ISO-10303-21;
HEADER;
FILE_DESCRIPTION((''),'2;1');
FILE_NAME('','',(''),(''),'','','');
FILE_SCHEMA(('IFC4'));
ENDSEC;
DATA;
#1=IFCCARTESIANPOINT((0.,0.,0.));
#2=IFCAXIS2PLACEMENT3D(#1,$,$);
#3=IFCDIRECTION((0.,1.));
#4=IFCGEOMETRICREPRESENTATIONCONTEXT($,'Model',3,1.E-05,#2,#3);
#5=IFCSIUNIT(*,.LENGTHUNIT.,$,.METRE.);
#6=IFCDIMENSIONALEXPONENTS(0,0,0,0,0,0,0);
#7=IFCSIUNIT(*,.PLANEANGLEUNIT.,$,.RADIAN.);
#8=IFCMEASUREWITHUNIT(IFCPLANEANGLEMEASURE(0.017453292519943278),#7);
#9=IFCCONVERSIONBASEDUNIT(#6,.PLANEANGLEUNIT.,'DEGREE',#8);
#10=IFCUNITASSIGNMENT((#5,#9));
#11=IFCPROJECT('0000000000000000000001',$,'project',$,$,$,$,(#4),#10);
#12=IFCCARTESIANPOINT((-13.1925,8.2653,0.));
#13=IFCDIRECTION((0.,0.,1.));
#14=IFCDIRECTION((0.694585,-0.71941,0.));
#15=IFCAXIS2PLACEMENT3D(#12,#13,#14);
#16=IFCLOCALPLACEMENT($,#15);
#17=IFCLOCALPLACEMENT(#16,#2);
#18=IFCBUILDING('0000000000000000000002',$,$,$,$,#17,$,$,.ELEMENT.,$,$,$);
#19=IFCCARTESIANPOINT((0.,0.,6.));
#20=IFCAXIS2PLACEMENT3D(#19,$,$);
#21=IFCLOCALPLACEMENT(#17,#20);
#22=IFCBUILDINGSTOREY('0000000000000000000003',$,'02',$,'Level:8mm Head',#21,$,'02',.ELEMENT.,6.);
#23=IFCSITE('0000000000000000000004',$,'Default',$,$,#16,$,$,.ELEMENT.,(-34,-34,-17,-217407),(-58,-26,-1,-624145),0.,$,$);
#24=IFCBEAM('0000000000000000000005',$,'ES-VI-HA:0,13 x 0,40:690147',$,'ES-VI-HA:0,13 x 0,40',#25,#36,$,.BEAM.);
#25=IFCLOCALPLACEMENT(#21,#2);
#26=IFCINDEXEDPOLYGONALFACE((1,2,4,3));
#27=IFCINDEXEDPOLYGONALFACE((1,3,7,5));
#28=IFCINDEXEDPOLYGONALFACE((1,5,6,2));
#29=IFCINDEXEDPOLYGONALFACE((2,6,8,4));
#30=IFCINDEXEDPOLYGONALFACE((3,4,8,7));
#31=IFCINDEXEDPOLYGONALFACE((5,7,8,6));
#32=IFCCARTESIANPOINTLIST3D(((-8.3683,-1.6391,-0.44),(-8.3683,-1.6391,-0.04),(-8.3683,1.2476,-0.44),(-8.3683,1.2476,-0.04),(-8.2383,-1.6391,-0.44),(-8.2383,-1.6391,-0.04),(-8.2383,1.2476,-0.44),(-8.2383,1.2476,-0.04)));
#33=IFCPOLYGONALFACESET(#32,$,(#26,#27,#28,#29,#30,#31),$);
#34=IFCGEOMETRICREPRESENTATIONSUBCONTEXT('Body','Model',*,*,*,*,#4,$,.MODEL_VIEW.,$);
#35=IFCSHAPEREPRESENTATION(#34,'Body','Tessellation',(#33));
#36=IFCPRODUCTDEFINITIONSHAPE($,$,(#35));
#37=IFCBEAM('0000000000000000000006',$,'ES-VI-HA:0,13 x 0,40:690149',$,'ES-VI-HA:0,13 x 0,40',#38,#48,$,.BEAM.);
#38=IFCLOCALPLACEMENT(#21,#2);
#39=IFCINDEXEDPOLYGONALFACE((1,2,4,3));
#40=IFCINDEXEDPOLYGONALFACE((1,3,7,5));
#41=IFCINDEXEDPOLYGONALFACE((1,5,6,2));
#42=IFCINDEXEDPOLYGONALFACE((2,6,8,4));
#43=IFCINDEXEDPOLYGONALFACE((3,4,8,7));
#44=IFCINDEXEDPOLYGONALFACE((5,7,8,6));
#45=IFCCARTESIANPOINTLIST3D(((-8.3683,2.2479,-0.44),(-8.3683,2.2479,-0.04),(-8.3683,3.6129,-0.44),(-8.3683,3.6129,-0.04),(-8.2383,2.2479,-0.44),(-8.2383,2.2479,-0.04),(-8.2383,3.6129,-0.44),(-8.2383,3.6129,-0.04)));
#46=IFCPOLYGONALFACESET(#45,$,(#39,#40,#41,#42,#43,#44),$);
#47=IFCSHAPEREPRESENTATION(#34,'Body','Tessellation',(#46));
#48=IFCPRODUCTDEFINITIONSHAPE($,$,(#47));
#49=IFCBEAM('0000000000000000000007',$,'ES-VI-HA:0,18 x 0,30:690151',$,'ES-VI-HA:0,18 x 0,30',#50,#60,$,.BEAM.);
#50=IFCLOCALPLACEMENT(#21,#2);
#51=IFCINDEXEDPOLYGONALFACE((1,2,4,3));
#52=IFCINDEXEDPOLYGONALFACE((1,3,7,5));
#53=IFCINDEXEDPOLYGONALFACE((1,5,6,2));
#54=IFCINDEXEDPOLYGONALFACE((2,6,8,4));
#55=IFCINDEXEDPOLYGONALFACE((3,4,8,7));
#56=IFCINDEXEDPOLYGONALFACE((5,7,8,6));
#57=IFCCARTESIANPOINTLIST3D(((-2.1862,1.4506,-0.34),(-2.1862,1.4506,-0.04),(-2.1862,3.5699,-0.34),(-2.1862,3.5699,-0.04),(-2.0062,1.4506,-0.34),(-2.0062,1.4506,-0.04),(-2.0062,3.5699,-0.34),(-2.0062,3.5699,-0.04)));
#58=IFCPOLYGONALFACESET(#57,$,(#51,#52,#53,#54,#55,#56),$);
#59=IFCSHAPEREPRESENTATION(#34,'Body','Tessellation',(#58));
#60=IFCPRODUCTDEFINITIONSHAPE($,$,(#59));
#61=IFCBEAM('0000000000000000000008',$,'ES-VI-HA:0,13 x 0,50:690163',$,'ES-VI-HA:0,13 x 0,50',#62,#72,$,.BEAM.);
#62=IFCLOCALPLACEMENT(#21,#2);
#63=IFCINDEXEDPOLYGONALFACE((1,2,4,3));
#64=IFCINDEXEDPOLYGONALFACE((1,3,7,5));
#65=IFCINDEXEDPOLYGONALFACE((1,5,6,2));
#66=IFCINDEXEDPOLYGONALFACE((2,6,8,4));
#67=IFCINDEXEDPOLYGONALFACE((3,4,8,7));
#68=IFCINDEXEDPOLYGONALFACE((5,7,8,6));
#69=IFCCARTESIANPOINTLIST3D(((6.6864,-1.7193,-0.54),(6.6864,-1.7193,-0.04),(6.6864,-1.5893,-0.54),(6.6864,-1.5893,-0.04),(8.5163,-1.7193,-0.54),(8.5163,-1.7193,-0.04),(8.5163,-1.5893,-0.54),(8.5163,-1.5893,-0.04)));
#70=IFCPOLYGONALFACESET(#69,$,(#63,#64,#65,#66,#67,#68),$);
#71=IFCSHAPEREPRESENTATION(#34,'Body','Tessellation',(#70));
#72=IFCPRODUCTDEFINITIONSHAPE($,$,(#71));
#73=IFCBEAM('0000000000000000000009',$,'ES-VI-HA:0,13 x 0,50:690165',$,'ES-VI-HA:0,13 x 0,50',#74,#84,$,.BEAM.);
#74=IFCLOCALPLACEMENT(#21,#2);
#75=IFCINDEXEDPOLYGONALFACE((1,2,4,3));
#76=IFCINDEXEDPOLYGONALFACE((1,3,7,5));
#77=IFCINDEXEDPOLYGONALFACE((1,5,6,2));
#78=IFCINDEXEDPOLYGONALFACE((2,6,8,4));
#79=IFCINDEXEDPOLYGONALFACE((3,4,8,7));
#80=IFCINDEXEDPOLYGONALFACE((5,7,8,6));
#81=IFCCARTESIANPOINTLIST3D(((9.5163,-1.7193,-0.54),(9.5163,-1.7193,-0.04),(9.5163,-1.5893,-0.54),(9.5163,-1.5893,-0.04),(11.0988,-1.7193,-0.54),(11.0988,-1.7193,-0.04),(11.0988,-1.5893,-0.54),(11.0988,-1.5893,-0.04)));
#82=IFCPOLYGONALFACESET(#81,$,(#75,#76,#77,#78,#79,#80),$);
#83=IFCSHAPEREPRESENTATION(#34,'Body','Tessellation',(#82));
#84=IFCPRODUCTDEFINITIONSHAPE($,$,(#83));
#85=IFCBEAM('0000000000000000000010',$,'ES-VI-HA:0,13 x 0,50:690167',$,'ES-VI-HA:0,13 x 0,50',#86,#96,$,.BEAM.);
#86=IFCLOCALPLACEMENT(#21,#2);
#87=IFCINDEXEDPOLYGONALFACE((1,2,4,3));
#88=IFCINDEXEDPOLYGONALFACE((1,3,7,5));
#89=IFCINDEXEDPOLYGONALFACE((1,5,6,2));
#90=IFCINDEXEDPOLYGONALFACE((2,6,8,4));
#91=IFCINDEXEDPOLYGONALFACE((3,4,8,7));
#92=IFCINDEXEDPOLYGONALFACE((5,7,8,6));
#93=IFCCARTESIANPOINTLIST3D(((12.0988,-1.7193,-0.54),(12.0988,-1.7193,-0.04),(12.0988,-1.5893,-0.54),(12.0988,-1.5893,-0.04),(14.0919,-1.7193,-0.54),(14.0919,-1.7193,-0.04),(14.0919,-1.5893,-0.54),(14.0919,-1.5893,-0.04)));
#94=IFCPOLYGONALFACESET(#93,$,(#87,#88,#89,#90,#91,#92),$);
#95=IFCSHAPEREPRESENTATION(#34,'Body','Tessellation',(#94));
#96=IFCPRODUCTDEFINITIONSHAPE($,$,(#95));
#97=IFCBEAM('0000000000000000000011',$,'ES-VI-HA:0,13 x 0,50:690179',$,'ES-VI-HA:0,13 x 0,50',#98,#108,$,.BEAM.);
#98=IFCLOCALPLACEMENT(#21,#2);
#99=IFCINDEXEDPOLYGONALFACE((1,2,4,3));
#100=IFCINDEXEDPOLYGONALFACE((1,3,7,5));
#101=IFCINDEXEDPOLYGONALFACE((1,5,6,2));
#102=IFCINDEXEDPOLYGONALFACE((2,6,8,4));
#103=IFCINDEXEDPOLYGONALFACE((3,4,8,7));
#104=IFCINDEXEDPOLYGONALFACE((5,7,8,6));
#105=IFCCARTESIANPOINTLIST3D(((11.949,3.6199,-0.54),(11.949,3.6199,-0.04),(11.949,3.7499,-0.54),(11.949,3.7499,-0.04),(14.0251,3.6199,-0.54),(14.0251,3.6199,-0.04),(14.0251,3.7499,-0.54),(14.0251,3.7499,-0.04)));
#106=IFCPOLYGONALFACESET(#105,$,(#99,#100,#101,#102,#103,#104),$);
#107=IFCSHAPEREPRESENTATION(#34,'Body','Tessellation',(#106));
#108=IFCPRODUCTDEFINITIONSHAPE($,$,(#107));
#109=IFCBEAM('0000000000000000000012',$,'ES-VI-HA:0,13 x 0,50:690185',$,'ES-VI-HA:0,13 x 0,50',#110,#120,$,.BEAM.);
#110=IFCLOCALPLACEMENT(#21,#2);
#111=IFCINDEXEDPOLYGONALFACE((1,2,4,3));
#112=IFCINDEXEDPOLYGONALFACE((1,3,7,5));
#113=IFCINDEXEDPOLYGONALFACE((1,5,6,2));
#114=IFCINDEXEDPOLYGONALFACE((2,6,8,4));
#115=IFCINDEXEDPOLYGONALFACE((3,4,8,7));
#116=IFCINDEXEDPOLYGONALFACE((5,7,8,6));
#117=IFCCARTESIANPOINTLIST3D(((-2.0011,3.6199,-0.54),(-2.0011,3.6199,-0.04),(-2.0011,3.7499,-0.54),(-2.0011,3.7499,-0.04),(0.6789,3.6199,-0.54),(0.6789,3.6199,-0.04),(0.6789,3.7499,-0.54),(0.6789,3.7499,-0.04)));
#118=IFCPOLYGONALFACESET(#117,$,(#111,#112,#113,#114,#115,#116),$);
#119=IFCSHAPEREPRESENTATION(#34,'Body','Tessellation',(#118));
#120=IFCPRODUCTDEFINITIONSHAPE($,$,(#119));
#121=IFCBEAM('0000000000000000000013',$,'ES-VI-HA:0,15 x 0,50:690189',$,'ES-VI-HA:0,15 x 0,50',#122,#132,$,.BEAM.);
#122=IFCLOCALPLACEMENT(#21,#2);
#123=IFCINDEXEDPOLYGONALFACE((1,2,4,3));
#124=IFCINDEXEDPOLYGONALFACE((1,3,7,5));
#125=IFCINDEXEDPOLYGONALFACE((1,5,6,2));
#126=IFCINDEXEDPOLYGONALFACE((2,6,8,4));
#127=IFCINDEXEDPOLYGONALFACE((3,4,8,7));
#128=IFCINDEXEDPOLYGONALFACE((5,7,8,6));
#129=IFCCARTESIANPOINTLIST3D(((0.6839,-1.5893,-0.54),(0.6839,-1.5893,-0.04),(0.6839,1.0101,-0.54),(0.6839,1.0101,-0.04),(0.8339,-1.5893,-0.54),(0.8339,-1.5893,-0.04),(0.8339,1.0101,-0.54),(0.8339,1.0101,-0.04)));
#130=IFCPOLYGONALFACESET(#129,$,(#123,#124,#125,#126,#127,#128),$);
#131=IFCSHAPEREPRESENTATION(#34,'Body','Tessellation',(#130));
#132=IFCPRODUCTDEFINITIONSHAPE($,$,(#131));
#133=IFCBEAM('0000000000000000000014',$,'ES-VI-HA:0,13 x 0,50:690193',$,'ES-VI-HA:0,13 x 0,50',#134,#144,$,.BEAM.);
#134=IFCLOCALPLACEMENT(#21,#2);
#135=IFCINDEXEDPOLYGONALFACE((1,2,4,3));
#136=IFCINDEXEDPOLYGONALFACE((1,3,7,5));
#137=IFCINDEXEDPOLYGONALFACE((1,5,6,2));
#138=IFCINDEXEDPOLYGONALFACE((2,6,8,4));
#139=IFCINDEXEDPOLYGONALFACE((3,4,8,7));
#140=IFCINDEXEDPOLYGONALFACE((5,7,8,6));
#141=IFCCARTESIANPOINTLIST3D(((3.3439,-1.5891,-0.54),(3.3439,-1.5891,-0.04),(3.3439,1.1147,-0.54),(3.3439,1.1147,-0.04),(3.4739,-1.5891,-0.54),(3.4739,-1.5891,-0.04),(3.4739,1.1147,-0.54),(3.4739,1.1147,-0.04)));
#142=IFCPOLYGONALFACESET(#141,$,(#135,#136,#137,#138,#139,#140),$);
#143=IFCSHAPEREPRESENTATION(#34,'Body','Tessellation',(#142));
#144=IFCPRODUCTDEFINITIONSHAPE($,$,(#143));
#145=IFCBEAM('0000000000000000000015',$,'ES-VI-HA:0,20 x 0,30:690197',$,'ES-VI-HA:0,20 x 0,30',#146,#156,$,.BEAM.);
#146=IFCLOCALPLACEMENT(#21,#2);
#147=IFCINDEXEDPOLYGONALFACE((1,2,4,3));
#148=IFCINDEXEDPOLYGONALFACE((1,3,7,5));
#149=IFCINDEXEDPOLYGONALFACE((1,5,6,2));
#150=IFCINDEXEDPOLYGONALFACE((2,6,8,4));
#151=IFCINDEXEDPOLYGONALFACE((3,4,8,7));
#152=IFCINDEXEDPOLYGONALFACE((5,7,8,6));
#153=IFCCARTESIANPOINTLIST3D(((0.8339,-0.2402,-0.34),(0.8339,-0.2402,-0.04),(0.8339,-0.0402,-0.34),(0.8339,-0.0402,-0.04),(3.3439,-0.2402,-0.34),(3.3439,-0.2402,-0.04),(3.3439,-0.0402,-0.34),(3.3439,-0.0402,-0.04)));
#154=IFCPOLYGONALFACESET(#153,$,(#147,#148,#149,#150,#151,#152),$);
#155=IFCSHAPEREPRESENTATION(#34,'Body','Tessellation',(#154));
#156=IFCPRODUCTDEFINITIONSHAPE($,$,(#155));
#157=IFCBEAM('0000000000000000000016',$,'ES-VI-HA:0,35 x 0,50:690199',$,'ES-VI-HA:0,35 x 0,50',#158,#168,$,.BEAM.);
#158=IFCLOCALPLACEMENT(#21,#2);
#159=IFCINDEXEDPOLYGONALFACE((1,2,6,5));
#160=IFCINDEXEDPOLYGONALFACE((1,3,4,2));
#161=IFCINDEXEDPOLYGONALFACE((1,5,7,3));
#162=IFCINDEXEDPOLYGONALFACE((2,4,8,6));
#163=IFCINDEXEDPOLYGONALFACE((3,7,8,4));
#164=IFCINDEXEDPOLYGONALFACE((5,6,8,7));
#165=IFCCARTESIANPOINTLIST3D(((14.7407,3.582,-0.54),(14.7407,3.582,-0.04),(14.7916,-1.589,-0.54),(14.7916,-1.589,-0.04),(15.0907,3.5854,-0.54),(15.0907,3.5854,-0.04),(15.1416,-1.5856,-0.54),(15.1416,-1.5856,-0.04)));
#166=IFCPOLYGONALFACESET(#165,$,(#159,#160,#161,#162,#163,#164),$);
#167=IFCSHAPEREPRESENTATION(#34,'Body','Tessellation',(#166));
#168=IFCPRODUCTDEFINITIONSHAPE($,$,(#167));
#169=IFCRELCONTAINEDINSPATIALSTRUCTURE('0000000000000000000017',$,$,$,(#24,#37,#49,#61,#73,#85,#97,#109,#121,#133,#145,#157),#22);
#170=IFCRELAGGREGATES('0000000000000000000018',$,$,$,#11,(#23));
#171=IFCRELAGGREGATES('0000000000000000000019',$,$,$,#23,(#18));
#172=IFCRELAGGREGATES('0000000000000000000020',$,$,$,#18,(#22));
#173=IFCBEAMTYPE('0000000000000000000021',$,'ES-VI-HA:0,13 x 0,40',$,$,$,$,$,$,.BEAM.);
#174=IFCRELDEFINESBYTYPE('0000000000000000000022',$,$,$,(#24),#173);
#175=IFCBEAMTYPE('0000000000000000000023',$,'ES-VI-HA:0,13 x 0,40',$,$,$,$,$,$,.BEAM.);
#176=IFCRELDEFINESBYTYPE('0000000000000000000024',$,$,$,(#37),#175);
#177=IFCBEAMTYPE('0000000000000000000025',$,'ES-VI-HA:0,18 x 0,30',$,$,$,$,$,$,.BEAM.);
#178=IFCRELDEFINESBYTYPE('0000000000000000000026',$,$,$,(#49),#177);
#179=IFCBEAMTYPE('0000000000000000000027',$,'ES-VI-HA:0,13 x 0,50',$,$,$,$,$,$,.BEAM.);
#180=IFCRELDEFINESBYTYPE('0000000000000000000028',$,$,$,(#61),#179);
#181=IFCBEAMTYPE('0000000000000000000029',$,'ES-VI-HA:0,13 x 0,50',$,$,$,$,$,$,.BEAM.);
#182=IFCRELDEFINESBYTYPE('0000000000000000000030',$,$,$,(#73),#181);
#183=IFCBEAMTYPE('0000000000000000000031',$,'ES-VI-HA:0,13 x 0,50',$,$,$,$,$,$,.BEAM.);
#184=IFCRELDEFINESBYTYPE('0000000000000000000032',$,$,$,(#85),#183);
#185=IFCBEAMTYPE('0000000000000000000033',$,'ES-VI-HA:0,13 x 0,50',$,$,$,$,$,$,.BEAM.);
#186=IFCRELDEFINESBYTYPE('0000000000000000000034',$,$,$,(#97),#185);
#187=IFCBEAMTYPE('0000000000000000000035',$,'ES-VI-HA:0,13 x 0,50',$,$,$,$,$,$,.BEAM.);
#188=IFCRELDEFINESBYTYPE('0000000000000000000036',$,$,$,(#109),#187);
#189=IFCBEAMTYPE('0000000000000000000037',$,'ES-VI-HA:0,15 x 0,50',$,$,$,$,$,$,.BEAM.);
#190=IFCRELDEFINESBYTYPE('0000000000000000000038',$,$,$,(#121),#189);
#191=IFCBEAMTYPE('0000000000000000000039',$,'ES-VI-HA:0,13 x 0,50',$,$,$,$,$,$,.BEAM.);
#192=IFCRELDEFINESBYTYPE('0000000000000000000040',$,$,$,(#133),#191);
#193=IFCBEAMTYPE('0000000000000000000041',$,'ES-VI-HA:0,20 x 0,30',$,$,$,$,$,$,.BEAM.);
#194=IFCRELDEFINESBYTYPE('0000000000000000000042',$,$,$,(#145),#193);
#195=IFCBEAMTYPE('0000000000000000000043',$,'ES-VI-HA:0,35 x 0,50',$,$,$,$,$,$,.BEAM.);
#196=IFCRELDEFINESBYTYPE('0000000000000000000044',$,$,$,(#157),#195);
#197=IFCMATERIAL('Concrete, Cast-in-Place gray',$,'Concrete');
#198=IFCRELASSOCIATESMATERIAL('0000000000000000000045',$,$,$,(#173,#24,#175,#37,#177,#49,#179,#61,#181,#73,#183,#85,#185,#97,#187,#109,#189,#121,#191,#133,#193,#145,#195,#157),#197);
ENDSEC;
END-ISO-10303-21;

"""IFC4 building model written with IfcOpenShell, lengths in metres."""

from ifc_helpers import new_model, entity, si_unit, converted_unit, direction, frame, origin, place, context, subcontext, project, spatial, indexed_curve, outline, extrude, source, transform, mapped, material, type_object, type_shapes, element, save


model = new_model("IFC4")

# Units and contexts
model_context = context("Model", 3, precision=1e-05, world=origin(), true_north=direction((0.0, 1.0)))
body_context = subcontext(model_context, "Body", "Model", "MODEL_VIEW")
ifc_project = project(units=[si_unit("LENGTHUNIT", "METRE"), converted_unit("PLANEANGLEUNIT", "DEGREE", entity("IfcPlaneAngleMeasure", 0.017453292519943278), si_unit("PLANEANGLEUNIT", "RADIAN"), dimensions=[0, 0, 0, 0, 0, 0, 0])], contexts=[model_context])

# Site, building, storey
site_placement = place(None, frame((-13.1925, 8.2653, 0.0), z_axis=(0.0, 0.0, 1.0), x_axis=(0.694585, -0.71941, 0.0)))
site = spatial("IfcSite", under=ifc_project, at=site_placement, Name="Default", CompositionType="ELEMENT", RefLatitude=(-34, -34, -17, -217407), RefLongitude=(-58, -26, -1, -624145), RefElevation=0.0)
building_placement = place(site_placement, origin())
building = spatial("IfcBuilding", under=site, at=building_placement, CompositionType="ELEMENT")
storey_placement = place(building_placement, frame((0.0, 0.0, 6.0)))
storey = spatial("IfcBuildingStorey", under=building, at=storey_placement, Name="02", ObjectType="Level:8mm Head", LongName="02", CompositionType="ELEMENT", Elevation=6.0)

# Beams
ifc_material = material(Name="Concrete, Cast-in-Place gray", Category="Concrete")
beam_type_1 = type_object("IfcBeamType", Name="ES-VI-HA:0,13 x 0,40", PredefinedType="BEAM", material=ifc_material)
shared_shape_1 = source(origin(), body_context, "Body", "SweptSolid", [
    extrude(outline(indexed_curve([(-0.065, -0.2), (0.065, -0.2), (0.065, 0.2), (-0.065, 0.2), (-0.065, -0.2)], self_intersect=False)), frame((-8.3033, -1.6391, 5.76), z_axis=(0.0, 1.0, 0.0), x_axis=(-1.0, 0.0, 0.0)), (0.0, 0.0, 1.0), 2.8867),
])
type_shapes(beam_type_1, [shared_shape_1])
beam_1_placement = place(storey_placement, frame((0.0, 0.0, -6.0)))
element("IfcBeam", 1, at=beam_1_placement, inside=storey, type_object=beam_type_1, material=ifc_material, Name="ES-VI-HA:0,13 x 0,40:690147", ObjectType="ES-VI-HA:0,13 x 0,40", PredefinedType="BEAM", context=body_context, shape_type="MappedRepresentation", body=[
    mapped(shared_shape_1, transform((0.0, 0.0, 0.0), scale=1.0)),
])
beam_type_2 = type_object("IfcBeamType", Name="ES-VI-HA:0,13 x 0,40", PredefinedType="BEAM", material=ifc_material)
shared_shape_2 = source(origin(), body_context, "Body", "SweptSolid", [
    extrude(outline(indexed_curve([(-0.065, -0.2), (0.065, -0.2), (0.065, 0.2), (-0.065, 0.2), (-0.065, -0.2)], self_intersect=False)), frame((-8.3033, 2.2479, 5.76), z_axis=(0.0, 1.0, 0.0), x_axis=(-1.0, 0.0, 0.0)), (0.0, 0.0, 1.0), 1.365),
])
type_shapes(beam_type_2, [shared_shape_2])
beam_2_placement = place(storey_placement, frame((0.0, 0.0, -6.0)))
element("IfcBeam", 2, at=beam_2_placement, inside=storey, type_object=beam_type_2, material=ifc_material, Name="ES-VI-HA:0,13 x 0,40:690149", ObjectType="ES-VI-HA:0,13 x 0,40", PredefinedType="BEAM", context=body_context, shape_type="MappedRepresentation", body=[
    mapped(shared_shape_2, transform((0.0, 0.0, 0.0), scale=1.0)),
])
beam_type_3 = type_object("IfcBeamType", Name="ES-VI-HA:0,18 x 0,30", PredefinedType="BEAM", material=ifc_material)
shared_shape_3 = source(origin(), body_context, "Body", "SweptSolid", [
    extrude(outline(indexed_curve([(-0.09, -0.15), (0.09, -0.15), (0.09, 0.15), (-0.09, 0.15), (-0.09, -0.15)], self_intersect=False)), frame((-2.0962, 3.5699, 5.81), z_axis=(0.0, -1.0, 0.0), x_axis=(-1.0, 0.0, 0.0)), (0.0, 0.0, 1.0), 2.1193),
])
type_shapes(beam_type_3, [shared_shape_3])
beam_3_placement = place(storey_placement, frame((0.0, 0.0, -6.0)))
element("IfcBeam", 3, at=beam_3_placement, inside=storey, type_object=beam_type_3, material=ifc_material, Name="ES-VI-HA:0,18 x 0,30:690151", ObjectType="ES-VI-HA:0,18 x 0,30", PredefinedType="BEAM", context=body_context, shape_type="MappedRepresentation", body=[
    mapped(shared_shape_3, transform((0.0, 0.0, 0.0), scale=1.0)),
])
beam_type_4 = type_object("IfcBeamType", Name="ES-VI-HA:0,13 x 0,50", PredefinedType="BEAM", material=ifc_material)
shared_shape_4 = source(origin(), body_context, "Body", "SweptSolid", [
    extrude(outline(indexed_curve([(-0.25, -0.065), (0.25, -0.065), (0.25, 0.065), (-0.25, 0.065), (-0.25, -0.065)], self_intersect=False)), frame((6.6864, -1.6543, 5.71), z_axis=(1.0, 0.0, 0.0), x_axis=(0.0, 0.0, -1.0)), (0.0, 0.0, 1.0), 1.8299),
])
type_shapes(beam_type_4, [shared_shape_4])
beam_4_placement = place(storey_placement, frame((0.0, 0.0, -6.0)))
element("IfcBeam", 4, at=beam_4_placement, inside=storey, type_object=beam_type_4, material=ifc_material, Name="ES-VI-HA:0,13 x 0,50:690163", ObjectType="ES-VI-HA:0,13 x 0,50", PredefinedType="BEAM", context=body_context, shape_type="MappedRepresentation", body=[
    mapped(shared_shape_4, transform((0.0, 0.0, 0.0), scale=1.0)),
])
beam_type_5 = type_object("IfcBeamType", Name="ES-VI-HA:0,13 x 0,50", PredefinedType="BEAM", material=ifc_material)
shared_shape_5 = source(origin(), body_context, "Body", "SweptSolid", [
    extrude(outline(indexed_curve([(-0.25, -0.065), (0.25, -0.065), (0.25, 0.065), (-0.25, 0.065), (-0.25, -0.065)], self_intersect=False)), frame((9.5163, -1.6543, 5.71), z_axis=(1.0, 0.0, 0.0), x_axis=(0.0, 0.0, -1.0)), (0.0, 0.0, 1.0), 1.5825),
])
type_shapes(beam_type_5, [shared_shape_5])
beam_5_placement = place(storey_placement, frame((0.0, 0.0, -6.0)))
element("IfcBeam", 5, at=beam_5_placement, inside=storey, type_object=beam_type_5, material=ifc_material, Name="ES-VI-HA:0,13 x 0,50:690165", ObjectType="ES-VI-HA:0,13 x 0,50", PredefinedType="BEAM", context=body_context, shape_type="MappedRepresentation", body=[
    mapped(shared_shape_5, transform((0.0, 0.0, 0.0), scale=1.0)),
])
beam_type_6 = type_object("IfcBeamType", Name="ES-VI-HA:0,13 x 0,50", PredefinedType="BEAM", material=ifc_material)
shared_shape_6 = source(origin(), body_context, "Body", "SweptSolid", [
    extrude(outline(indexed_curve([(-0.25, -0.065), (0.25, -0.065), (0.25, 0.065), (-0.25, 0.065), (-0.25, -0.065)], self_intersect=False)), frame((12.0988, -1.6543, 5.71), z_axis=(1.0, 0.0, 0.0), x_axis=(0.0, 0.0, -1.0)), (0.0, 0.0, 1.0), 1.9932),
])
type_shapes(beam_type_6, [shared_shape_6])
beam_6_placement = place(storey_placement, frame((0.0, 0.0, -6.0)))
element("IfcBeam", 6, at=beam_6_placement, inside=storey, type_object=beam_type_6, material=ifc_material, Name="ES-VI-HA:0,13 x 0,50:690167", ObjectType="ES-VI-HA:0,13 x 0,50", PredefinedType="BEAM", context=body_context, shape_type="MappedRepresentation", body=[
    mapped(shared_shape_6, transform((0.0, 0.0, 0.0), scale=1.0)),
])
beam_type_7 = type_object("IfcBeamType", Name="ES-VI-HA:0,13 x 0,50", PredefinedType="BEAM", material=ifc_material)
shared_shape_7 = source(origin(), body_context, "Body", "SweptSolid", [
    extrude(outline(indexed_curve([(-0.25, -0.065), (0.25, -0.065), (0.25, 0.065), (-0.25, 0.065), (-0.25, -0.065)], self_intersect=False)), frame((11.949, 3.6849, 5.71), z_axis=(1.0, 0.0, 0.0), x_axis=(0.0, 0.0, -1.0)), (0.0, 0.0, 1.0), 2.0761),
])
type_shapes(beam_type_7, [shared_shape_7])
beam_7_placement = place(storey_placement, frame((0.0, 0.0, -6.0)))
element("IfcBeam", 7, at=beam_7_placement, inside=storey, type_object=beam_type_7, material=ifc_material, Name="ES-VI-HA:0,13 x 0,50:690179", ObjectType="ES-VI-HA:0,13 x 0,50", PredefinedType="BEAM", context=body_context, shape_type="MappedRepresentation", body=[
    mapped(shared_shape_7, transform((0.0, 0.0, 0.0), scale=1.0)),
])
beam_type_8 = type_object("IfcBeamType", Name="ES-VI-HA:0,13 x 0,50", PredefinedType="BEAM", material=ifc_material)
shared_shape_8 = source(origin(), body_context, "Body", "SweptSolid", [
    extrude(outline(indexed_curve([(-0.25, -0.065), (0.25, -0.065), (0.25, 0.065), (-0.25, 0.065), (-0.25, -0.065)], self_intersect=False)), frame((-2.0011, 3.6849, 5.71), z_axis=(1.0, 0.0, 0.0), x_axis=(0.0, 0.0, -1.0)), (0.0, 0.0, 1.0), 2.68),
])
type_shapes(beam_type_8, [shared_shape_8])
beam_8_placement = place(storey_placement, frame((0.0, 0.0, -6.0)))
element("IfcBeam", 8, at=beam_8_placement, inside=storey, type_object=beam_type_8, material=ifc_material, Name="ES-VI-HA:0,13 x 0,50:690185", ObjectType="ES-VI-HA:0,13 x 0,50", PredefinedType="BEAM", context=body_context, shape_type="MappedRepresentation", body=[
    mapped(shared_shape_8, transform((0.0, 0.0, 0.0), scale=1.0)),
])
beam_type_9 = type_object("IfcBeamType", Name="ES-VI-HA:0,15 x 0,50", PredefinedType="BEAM", material=ifc_material)
shared_shape_9 = source(origin(), body_context, "Body", "SweptSolid", [
    extrude(outline(indexed_curve([(-0.075, -0.25), (0.075, -0.25), (0.075, 0.25), (-0.075, 0.25), (-0.075, -0.25)], self_intersect=False)), frame((0.7589, -1.5893, 5.71), z_axis=(0.0, 1.0, 0.0), x_axis=(-1.0, 0.0, 0.0)), (0.0, 0.0, 1.0), 2.5994),
])
type_shapes(beam_type_9, [shared_shape_9])
beam_9_placement = place(storey_placement, frame((0.0, 0.0, -6.0)))
element("IfcBeam", 9, at=beam_9_placement, inside=storey, type_object=beam_type_9, material=ifc_material, Name="ES-VI-HA:0,15 x 0,50:690189", ObjectType="ES-VI-HA:0,15 x 0,50", PredefinedType="BEAM", context=body_context, shape_type="MappedRepresentation", body=[
    mapped(shared_shape_9, transform((0.0, 0.0, 0.0), scale=1.0)),
])
beam_type_10 = type_object("IfcBeamType", Name="ES-VI-HA:0,13 x 0,50", PredefinedType="BEAM", material=ifc_material)
shared_shape_10 = source(origin(), body_context, "Body", "SweptSolid", [
    extrude(outline(indexed_curve([(-0.065, -0.25), (0.065, -0.25), (0.065, 0.25), (-0.065, 0.25), (-0.065, -0.25)], self_intersect=False)), frame((3.4089, -1.5891, 5.71), z_axis=(0.0, 1.0, 0.0), x_axis=(-1.0, 0.0, 0.0)), (0.0, 0.0, 1.0), 2.7037),
])
type_shapes(beam_type_10, [shared_shape_10])
beam_10_placement = place(storey_placement, frame((0.0, 0.0, -6.0)))
element("IfcBeam", 10, at=beam_10_placement, inside=storey, type_object=beam_type_10, material=ifc_material, Name="ES-VI-HA:0,13 x 0,50:690193", ObjectType="ES-VI-HA:0,13 x 0,50", PredefinedType="BEAM", context=body_context, shape_type="MappedRepresentation", body=[
    mapped(shared_shape_10, transform((0.0, 0.0, 0.0), scale=1.0)),
])
beam_type_11 = type_object("IfcBeamType", Name="ES-VI-HA:0,20 x 0,30", PredefinedType="BEAM", material=ifc_material)
shared_shape_11 = source(origin(), body_context, "Body", "SweptSolid", [
    extrude(outline(indexed_curve([(-0.15, -0.1), (0.15, -0.1), (0.15, 0.1), (-0.15, 0.1), (-0.15, -0.1)], self_intersect=False)), frame((0.8339, -0.1402, 5.81), z_axis=(1.0, 0.0, 0.0), x_axis=(0.0, 0.0, -1.0)), (0.0, 0.0, 1.0), 2.51),
])
type_shapes(beam_type_11, [shared_shape_11])
beam_11_placement = place(storey_placement, frame((0.0, 0.0, -6.0)))
element("IfcBeam", 11, at=beam_11_placement, inside=storey, type_object=beam_type_11, material=ifc_material, Name="ES-VI-HA:0,20 x 0,30:690197", ObjectType="ES-VI-HA:0,20 x 0,30", PredefinedType="BEAM", context=body_context, shape_type="MappedRepresentation", body=[
    mapped(shared_shape_11, transform((0.0, 0.0, 0.0), scale=1.0)),
])
beam_type_12 = type_object("IfcBeamType", Name="ES-VI-HA:0,35 x 0,50", PredefinedType="BEAM", material=ifc_material)
shared_shape_12 = source(origin(), body_context, "Body", "SweptSolid", [
    extrude(outline(indexed_curve([(-0.25, -0.175), (0.25, -0.175), (0.25, 0.175), (-0.25, 0.175), (-0.25, -0.175)], self_intersect=False)), frame((14.9157, 3.5837, 5.71), z_axis=(0.009844, -0.999952, 0.0), x_axis=(0.0, 0.0, -1.0)), (0.0, 0.0, 1.0), 5.1713),
])
type_shapes(beam_type_12, [shared_shape_12])
beam_12_placement = place(storey_placement, frame((0.0, 0.0, -6.0)))
element("IfcBeam", 12, at=beam_12_placement, inside=storey, type_object=beam_type_12, material=ifc_material, Name="ES-VI-HA:0,35 x 0,50:690199", ObjectType="ES-VI-HA:0,35 x 0,50", PredefinedType="BEAM", context=body_context, shape_type="MappedRepresentation", body=[
    mapped(shared_shape_12, transform((0.0, 0.0, 0.0), scale=1.0)),
])

save(model, "model.ifc")
